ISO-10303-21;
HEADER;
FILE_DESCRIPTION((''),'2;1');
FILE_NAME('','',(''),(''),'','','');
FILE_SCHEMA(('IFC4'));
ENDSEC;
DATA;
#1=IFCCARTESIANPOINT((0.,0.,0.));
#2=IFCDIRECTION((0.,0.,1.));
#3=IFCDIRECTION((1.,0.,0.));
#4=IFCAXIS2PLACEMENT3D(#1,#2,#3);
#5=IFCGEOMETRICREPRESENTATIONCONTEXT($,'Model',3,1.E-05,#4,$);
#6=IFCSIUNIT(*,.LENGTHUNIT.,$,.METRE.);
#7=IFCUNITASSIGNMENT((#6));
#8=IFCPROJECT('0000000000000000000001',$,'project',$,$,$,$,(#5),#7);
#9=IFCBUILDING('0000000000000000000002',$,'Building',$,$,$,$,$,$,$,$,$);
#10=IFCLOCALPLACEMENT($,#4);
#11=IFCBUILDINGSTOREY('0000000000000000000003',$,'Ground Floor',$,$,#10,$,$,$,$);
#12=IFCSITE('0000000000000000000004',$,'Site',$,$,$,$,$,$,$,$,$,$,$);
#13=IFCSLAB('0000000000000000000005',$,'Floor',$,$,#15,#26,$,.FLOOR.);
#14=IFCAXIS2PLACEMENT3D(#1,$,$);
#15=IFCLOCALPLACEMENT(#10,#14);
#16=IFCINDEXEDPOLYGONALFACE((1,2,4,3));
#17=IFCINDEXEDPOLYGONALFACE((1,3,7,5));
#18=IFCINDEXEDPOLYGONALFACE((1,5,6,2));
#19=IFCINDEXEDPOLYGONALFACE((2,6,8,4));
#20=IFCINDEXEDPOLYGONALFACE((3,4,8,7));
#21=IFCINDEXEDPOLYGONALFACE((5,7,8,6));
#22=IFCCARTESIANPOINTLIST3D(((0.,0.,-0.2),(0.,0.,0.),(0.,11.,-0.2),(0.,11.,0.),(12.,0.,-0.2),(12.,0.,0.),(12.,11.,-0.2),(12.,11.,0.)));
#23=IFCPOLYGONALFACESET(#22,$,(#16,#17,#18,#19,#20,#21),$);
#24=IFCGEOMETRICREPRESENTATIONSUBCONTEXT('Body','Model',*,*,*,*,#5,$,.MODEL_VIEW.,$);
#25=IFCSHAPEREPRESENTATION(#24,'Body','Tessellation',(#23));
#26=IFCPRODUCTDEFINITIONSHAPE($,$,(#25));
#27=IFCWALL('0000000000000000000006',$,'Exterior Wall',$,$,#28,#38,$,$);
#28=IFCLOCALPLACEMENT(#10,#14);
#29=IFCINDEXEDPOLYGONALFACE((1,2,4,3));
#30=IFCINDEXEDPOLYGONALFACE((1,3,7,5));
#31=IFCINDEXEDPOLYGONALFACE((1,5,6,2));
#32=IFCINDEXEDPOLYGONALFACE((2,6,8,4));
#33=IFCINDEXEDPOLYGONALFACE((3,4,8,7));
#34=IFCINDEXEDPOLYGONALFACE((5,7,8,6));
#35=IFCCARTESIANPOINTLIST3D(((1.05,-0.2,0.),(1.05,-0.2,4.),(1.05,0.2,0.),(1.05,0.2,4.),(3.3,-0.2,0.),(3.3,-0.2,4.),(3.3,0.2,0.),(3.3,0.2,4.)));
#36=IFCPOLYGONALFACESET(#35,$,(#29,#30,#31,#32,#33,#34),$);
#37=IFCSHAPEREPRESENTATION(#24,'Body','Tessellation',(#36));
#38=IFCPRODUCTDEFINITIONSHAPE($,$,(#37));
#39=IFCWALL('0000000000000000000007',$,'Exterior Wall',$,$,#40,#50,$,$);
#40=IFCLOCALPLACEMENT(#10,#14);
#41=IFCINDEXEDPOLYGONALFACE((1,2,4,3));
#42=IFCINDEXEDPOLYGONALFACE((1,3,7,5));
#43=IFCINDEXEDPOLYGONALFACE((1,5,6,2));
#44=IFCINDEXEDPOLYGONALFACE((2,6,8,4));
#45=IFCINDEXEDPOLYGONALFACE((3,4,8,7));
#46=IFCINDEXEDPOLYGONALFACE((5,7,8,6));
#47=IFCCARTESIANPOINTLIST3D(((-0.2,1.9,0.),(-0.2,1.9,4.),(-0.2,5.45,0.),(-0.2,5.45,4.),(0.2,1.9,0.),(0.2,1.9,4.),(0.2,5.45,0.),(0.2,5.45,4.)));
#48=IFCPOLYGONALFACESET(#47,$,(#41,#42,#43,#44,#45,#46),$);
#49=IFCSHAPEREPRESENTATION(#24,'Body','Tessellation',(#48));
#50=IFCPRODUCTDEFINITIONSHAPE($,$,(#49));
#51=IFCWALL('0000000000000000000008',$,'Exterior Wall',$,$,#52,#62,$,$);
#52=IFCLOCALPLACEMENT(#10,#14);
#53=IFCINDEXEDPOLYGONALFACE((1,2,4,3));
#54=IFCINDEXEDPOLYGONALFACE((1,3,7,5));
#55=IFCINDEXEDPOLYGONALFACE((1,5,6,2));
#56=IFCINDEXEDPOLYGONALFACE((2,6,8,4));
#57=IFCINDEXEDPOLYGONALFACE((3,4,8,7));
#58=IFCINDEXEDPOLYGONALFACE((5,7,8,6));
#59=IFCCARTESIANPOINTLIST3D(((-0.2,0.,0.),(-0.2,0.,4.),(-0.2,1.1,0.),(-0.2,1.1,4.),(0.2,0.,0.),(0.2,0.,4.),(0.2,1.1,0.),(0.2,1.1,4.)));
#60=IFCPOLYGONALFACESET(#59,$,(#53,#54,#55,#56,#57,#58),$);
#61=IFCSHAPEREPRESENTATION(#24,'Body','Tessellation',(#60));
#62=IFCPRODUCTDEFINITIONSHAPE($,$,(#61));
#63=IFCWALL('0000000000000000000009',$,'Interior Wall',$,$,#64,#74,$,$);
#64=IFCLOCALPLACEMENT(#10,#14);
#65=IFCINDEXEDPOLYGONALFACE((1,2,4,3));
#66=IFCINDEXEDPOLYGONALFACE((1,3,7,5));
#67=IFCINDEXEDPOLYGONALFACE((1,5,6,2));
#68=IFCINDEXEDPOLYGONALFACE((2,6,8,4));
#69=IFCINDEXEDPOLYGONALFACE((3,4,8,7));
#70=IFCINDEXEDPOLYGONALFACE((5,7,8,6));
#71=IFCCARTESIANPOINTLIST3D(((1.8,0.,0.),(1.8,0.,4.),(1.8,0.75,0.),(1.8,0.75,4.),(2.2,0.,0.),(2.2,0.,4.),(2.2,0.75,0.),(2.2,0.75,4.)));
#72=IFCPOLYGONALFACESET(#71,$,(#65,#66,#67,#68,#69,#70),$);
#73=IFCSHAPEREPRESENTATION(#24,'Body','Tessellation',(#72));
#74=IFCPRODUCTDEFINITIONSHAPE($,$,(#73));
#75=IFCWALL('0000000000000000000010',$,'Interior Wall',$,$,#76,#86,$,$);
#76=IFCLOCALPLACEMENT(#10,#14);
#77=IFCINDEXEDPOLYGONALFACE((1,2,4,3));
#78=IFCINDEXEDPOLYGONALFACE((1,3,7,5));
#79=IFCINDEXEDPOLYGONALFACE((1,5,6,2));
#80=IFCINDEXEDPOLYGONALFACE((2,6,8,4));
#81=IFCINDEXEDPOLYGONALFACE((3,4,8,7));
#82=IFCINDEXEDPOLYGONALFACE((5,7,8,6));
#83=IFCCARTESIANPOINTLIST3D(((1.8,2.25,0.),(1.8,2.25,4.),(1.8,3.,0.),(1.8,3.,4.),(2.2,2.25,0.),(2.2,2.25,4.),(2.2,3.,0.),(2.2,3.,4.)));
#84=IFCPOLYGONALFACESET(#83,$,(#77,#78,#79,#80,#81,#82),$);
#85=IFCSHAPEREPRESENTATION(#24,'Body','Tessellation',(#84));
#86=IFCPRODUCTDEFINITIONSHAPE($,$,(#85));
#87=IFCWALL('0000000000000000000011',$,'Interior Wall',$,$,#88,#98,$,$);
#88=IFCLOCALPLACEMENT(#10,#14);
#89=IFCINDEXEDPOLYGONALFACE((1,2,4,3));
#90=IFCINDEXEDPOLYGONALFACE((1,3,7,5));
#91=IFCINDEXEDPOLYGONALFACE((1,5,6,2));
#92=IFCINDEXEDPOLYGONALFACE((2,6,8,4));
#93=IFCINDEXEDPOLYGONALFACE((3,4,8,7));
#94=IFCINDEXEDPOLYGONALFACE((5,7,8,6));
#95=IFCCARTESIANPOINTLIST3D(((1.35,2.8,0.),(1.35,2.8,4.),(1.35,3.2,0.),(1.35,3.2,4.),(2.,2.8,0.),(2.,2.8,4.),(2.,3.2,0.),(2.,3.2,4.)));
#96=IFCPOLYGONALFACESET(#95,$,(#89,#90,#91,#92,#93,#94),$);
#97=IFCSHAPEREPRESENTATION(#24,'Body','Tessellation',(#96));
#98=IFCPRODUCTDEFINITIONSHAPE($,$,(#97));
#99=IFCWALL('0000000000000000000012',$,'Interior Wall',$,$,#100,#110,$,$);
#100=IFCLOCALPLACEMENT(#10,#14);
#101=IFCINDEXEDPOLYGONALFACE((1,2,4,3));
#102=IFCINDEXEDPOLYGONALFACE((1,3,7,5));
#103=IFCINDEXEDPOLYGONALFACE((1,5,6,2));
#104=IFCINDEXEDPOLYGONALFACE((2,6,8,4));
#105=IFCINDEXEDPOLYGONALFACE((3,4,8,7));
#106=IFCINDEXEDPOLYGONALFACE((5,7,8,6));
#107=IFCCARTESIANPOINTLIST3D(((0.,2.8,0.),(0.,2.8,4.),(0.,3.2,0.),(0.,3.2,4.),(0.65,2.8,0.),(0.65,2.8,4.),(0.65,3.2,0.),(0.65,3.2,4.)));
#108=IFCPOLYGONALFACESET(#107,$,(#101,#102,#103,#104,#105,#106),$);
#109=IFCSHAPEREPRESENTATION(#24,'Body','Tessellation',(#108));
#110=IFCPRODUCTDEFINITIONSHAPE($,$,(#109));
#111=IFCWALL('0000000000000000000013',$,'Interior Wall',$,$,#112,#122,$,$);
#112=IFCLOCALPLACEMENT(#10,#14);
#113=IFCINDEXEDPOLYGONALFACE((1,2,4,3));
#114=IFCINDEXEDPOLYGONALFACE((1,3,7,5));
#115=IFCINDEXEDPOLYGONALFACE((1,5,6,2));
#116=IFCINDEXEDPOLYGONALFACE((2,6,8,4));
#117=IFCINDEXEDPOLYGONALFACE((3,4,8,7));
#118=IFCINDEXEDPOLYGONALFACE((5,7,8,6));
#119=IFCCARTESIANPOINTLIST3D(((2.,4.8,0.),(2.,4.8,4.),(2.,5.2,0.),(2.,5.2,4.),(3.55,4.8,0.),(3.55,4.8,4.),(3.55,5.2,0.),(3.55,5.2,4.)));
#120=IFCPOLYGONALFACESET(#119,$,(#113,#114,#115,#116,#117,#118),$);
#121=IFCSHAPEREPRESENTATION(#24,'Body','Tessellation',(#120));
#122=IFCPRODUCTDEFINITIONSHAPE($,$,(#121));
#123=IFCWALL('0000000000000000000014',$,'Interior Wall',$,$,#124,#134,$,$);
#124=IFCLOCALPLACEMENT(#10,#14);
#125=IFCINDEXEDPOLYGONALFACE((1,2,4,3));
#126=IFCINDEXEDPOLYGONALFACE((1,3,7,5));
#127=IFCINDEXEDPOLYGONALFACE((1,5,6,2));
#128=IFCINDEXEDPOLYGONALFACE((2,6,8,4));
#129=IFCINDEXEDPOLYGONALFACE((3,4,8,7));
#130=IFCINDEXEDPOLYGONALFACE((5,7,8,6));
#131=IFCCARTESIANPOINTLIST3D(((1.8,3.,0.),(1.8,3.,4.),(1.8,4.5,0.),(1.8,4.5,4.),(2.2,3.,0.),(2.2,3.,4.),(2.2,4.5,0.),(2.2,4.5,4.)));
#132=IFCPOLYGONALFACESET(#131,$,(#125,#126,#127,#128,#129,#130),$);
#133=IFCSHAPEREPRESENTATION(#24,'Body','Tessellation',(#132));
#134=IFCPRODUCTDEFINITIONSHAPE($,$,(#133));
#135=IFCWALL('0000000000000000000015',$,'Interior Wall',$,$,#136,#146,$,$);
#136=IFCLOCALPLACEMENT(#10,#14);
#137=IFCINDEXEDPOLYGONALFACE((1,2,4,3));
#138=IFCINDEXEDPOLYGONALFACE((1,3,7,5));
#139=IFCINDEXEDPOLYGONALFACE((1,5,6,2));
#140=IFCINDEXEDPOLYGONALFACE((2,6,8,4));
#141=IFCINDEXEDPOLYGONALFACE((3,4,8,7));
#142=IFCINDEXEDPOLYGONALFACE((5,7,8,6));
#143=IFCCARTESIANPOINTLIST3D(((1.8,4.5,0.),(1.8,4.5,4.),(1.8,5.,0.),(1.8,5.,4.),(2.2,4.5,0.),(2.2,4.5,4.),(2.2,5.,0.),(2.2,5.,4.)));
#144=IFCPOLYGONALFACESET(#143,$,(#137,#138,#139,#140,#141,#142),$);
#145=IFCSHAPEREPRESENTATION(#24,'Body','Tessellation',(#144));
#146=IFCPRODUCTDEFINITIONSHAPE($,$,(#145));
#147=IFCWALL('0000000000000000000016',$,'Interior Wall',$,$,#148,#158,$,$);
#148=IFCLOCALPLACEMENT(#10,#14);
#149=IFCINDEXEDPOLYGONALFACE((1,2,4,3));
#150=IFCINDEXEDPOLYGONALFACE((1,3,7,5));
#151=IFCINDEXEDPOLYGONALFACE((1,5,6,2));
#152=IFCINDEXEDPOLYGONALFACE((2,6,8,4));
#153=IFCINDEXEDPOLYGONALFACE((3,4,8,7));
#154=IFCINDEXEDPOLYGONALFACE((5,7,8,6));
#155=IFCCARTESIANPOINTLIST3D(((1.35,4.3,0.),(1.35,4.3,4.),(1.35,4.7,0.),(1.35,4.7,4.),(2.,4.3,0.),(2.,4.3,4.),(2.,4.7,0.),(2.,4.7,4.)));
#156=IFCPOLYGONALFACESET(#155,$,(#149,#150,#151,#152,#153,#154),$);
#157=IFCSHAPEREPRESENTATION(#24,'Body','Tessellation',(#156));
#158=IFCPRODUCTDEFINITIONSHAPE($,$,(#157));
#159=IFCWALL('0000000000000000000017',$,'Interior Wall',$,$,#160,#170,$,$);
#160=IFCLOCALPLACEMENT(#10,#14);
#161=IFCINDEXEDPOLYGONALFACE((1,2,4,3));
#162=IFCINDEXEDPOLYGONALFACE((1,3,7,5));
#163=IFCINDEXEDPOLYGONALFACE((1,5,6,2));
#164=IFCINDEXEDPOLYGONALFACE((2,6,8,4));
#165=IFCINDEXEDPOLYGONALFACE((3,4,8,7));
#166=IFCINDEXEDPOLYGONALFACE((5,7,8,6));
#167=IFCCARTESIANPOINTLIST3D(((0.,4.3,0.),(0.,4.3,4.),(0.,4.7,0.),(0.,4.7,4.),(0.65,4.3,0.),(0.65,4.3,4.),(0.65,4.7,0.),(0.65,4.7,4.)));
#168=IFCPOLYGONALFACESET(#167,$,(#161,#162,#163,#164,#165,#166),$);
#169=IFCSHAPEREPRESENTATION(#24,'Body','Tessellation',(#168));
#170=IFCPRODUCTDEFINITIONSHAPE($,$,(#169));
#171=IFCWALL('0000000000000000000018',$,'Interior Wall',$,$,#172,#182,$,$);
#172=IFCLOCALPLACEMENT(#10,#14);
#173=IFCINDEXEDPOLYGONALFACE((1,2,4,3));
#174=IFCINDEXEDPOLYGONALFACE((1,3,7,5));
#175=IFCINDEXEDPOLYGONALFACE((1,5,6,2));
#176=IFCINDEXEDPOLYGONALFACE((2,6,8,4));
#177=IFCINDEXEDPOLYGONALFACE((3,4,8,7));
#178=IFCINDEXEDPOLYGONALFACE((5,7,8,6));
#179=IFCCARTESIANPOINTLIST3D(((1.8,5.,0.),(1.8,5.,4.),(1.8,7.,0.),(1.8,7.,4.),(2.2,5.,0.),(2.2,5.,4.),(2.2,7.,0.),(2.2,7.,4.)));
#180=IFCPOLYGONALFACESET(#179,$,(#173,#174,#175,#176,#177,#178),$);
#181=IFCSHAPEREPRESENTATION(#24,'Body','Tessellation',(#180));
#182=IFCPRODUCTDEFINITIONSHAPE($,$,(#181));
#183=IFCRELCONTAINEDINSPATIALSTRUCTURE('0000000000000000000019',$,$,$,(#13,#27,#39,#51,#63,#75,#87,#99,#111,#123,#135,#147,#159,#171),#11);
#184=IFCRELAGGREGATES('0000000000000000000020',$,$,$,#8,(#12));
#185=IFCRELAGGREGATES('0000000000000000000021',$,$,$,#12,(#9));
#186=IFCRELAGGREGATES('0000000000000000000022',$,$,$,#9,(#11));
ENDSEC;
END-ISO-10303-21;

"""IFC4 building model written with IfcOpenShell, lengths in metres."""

from ifc_helpers import new_model, si_unit, frame, origin_with_axes, place, context, subcontext, project, spatial, indexed_curve, outline, extrude, element, save


model = new_model("IFC4")

# Units and contexts
model_context = context("Model", 3, precision=1e-05, world=origin_with_axes())
body_context = subcontext(model_context, "Body", "Model", "MODEL_VIEW")
ifc_project = project(units=[si_unit("LENGTHUNIT", "METRE")], contexts=[model_context])

# Site, building, storey
site = spatial("IfcSite", under=ifc_project, Name="Site")
building = spatial("IfcBuilding", under=site, Name="Building")
storey_placement = place(None, origin_with_axes())
storey = spatial("IfcBuildingStorey", under=building, at=storey_placement, Name="Ground Floor")

# Slab
slab_placement = place(storey_placement, frame((0.0, 0.0, -0.2), z_axis=(0.0, 0.0, 1.0), x_axis=(1.0, 0.0, 0.0)))
element("IfcSlab", 1, at=slab_placement, inside=storey, Name="Floor", PredefinedType="FLOOR", context=body_context, shape_type="SweptSolid", body=[
    extrude(outline(indexed_curve([(0.0, 0.0), (12.0, 0.0), (12.0, 11.0), (0.0, 11.0)])), None, (0.0, 0.0, 1.0), 0.2),
])

# Walls
wall_1_placement = place(storey_placement, frame((1.05, 0.0, 0.0), z_axis=(0.0, 0.0, 1.0), x_axis=(1.0, 0.0, 0.0)))
element("IfcWall", 2, at=wall_1_placement, inside=storey, Name="Exterior Wall", context=body_context, shape_type="SweptSolid", body=[
    extrude(outline(indexed_curve([(0.0, 0.0), (0.0, 0.4), (2.25, 0.4), (2.25, 0.0), (0.0, 0.0)], self_intersect=False)), frame((0.0, -0.2, 0.0), z_axis=(0.0, 0.0, 1.0), x_axis=(1.0, 0.0, 0.0)), (0.0, 0.0, 1.0), 4.0),
])
wall_2_placement = place(storey_placement, frame((0.0, 5.45, 0.0), z_axis=(0.0, 0.0, 1.0), x_axis=(0.0, -1.0, 0.0)))
element("IfcWall", 3, at=wall_2_placement, inside=storey, Name="Exterior Wall", context=body_context, shape_type="SweptSolid", body=[
    extrude(outline(indexed_curve([(0.0, 0.0), (0.0, 0.4), (3.55, 0.4), (3.55, 0.0), (0.0, 0.0)], self_intersect=False)), frame((0.0, -0.2, 0.0), z_axis=(0.0, 0.0, 1.0), x_axis=(1.0, 0.0, 0.0)), (0.0, 0.0, 1.0), 4.0),
])
wall_3_placement = place(storey_placement, frame((0.0, 1.1, 0.0), z_axis=(0.0, 0.0, 1.0), x_axis=(0.0, -1.0, 0.0)))
element("IfcWall", 4, at=wall_3_placement, inside=storey, Name="Exterior Wall", context=body_context, shape_type="SweptSolid", body=[
    extrude(outline(indexed_curve([(0.0, 0.0), (0.0, 0.4), (1.1, 0.4), (1.1, 0.0), (0.0, 0.0)], self_intersect=False)), frame((0.0, -0.2, 0.0), z_axis=(0.0, 0.0, 1.0), x_axis=(1.0, 0.0, 0.0)), (0.0, 0.0, 1.0), 4.0),
])
for number, where, z_axis, x_axis, name in (
    (5, (2.0, 0.0, 0.0), (0.0, 0.0, 1.0), (0.0, 1.0, 0.0), "Interior Wall"),
    (6, (2.0, 2.25, 0.0), (0.0, 0.0, 1.0), (0.0, 1.0, 0.0), "Interior Wall"),
):
    element("IfcWall", number, at=place(storey_placement, frame(where, z_axis=z_axis, x_axis=x_axis)), inside=storey, Name=name, context=body_context, shape_type="SweptSolid", body=[
        extrude(outline(indexed_curve([(0.0, 0.0), (0.0, 0.4), (0.75, 0.4), (0.75, 0.0), (0.0, 0.0)], self_intersect=False)), frame((0.0, -0.2, 0.0), z_axis=(0.0, 0.0, 1.0), x_axis=(1.0, 0.0, 0.0)), (0.0, 0.0, 1.0), 4.0),
    ])
for number, where, z_axis, x_axis, name in (
    (7, (2.0, 3.0, 0.0), (0.0, 0.0, 1.0), (-1.0, 0.0, 0.0), "Interior Wall"),
    (8, (0.65, 3.0, 0.0), (0.0, 0.0, 1.0), (-1.0, 0.0, 0.0), "Interior Wall"),
):
    element("IfcWall", number, at=place(storey_placement, frame(where, z_axis=z_axis, x_axis=x_axis)), inside=storey, Name=name, context=body_context, shape_type="SweptSolid", body=[
        extrude(outline(indexed_curve([(0.0, 0.0), (0.0, 0.4), (0.65, 0.4), (0.65, 0.0), (0.0, 0.0)], self_intersect=False)), frame((0.0, -0.2, 0.0), z_axis=(0.0, 0.0, 1.0), x_axis=(1.0, 0.0, 0.0)), (0.0, 0.0, 1.0), 4.0),
    ])
wall_4_placement = place(storey_placement, frame((3.55, 5.0, 0.0), z_axis=(0.0, 0.0, 1.0), x_axis=(-1.0, 0.0, 0.0)))
element("IfcWall", 9, at=wall_4_placement, inside=storey, Name="Interior Wall", context=body_context, shape_type="SweptSolid", body=[
    extrude(outline(indexed_curve([(0.0, 0.0), (0.0, 0.4), (1.55, 0.4), (1.55, 0.0), (0.0, 0.0)], self_intersect=False)), frame((0.0, -0.2, 0.0), z_axis=(0.0, 0.0, 1.0), x_axis=(1.0, 0.0, 0.0)), (0.0, 0.0, 1.0), 4.0),
])
wall_5_placement = place(storey_placement, frame((2.0, 4.5, 0.0), z_axis=(0.0, 0.0, 1.0), x_axis=(0.0, -1.0, 0.0)))
element("IfcWall", 10, at=wall_5_placement, inside=storey, Name="Interior Wall", context=body_context, shape_type="SweptSolid", body=[
    extrude(outline(indexed_curve([(0.0, 0.0), (0.0, 0.4), (1.5, 0.4), (1.5, 0.0), (0.0, 0.0)], self_intersect=False)), frame((0.0, -0.2, 0.0), z_axis=(0.0, 0.0, 1.0), x_axis=(1.0, 0.0, 0.0)), (0.0, 0.0, 1.0), 4.0),
])
wall_6_placement = place(storey_placement, frame((2.0, 5.0, 0.0), z_axis=(0.0, 0.0, 1.0), x_axis=(0.0, -1.0, 0.0)))
element("IfcWall", 11, at=wall_6_placement, inside=storey, Name="Interior Wall", context=body_context, shape_type="SweptSolid", body=[
    extrude(outline(indexed_curve([(0.0, 0.0), (0.0, 0.4), (0.5, 0.4), (0.5, 0.0), (0.0, 0.0)], self_intersect=False)), frame((0.0, -0.2, 0.0), z_axis=(0.0, 0.0, 1.0), x_axis=(1.0, 0.0, 0.0)), (0.0, 0.0, 1.0), 4.0),
])
for number, where, z_axis, x_axis, name in (
    (12, (2.0, 4.5, 0.0), (0.0, 0.0, 1.0), (-1.0, 0.0, 0.0), "Interior Wall"),
    (13, (0.65, 4.5, 0.0), (0.0, 0.0, 1.0), (-1.0, 0.0, 0.0), "Interior Wall"),
):
    element("IfcWall", number, at=place(storey_placement, frame(where, z_axis=z_axis, x_axis=x_axis)), inside=storey, Name=name, context=body_context, shape_type="SweptSolid", body=[
        extrude(outline(indexed_curve([(0.0, 0.0), (0.0, 0.4), (0.65, 0.4), (0.65, 0.0), (0.0, 0.0)], self_intersect=False)), frame((0.0, -0.2, 0.0), z_axis=(0.0, 0.0, 1.0), x_axis=(1.0, 0.0, 0.0)), (0.0, 0.0, 1.0), 4.0),
    ])
wall_7_placement = place(storey_placement, frame((2.0, 5.0, 0.0), z_axis=(0.0, 0.0, 1.0), x_axis=(0.0, 1.0, 0.0)))
element("IfcWall", 14, at=wall_7_placement, inside=storey, Name="Interior Wall", context=body_context, shape_type="SweptSolid", body=[
    extrude(outline(indexed_curve([(0.0, 0.0), (0.0, 0.4), (2.0, 0.4), (2.0, 0.0), (0.0, 0.0)], self_intersect=False)), frame((0.0, -0.2, 0.0), z_axis=(0.0, 0.0, 1.0), x_axis=(1.0, 0.0, 0.0)), (0.0, 0.0, 1.0), 4.0),
])

save(model, "model.ifc")
